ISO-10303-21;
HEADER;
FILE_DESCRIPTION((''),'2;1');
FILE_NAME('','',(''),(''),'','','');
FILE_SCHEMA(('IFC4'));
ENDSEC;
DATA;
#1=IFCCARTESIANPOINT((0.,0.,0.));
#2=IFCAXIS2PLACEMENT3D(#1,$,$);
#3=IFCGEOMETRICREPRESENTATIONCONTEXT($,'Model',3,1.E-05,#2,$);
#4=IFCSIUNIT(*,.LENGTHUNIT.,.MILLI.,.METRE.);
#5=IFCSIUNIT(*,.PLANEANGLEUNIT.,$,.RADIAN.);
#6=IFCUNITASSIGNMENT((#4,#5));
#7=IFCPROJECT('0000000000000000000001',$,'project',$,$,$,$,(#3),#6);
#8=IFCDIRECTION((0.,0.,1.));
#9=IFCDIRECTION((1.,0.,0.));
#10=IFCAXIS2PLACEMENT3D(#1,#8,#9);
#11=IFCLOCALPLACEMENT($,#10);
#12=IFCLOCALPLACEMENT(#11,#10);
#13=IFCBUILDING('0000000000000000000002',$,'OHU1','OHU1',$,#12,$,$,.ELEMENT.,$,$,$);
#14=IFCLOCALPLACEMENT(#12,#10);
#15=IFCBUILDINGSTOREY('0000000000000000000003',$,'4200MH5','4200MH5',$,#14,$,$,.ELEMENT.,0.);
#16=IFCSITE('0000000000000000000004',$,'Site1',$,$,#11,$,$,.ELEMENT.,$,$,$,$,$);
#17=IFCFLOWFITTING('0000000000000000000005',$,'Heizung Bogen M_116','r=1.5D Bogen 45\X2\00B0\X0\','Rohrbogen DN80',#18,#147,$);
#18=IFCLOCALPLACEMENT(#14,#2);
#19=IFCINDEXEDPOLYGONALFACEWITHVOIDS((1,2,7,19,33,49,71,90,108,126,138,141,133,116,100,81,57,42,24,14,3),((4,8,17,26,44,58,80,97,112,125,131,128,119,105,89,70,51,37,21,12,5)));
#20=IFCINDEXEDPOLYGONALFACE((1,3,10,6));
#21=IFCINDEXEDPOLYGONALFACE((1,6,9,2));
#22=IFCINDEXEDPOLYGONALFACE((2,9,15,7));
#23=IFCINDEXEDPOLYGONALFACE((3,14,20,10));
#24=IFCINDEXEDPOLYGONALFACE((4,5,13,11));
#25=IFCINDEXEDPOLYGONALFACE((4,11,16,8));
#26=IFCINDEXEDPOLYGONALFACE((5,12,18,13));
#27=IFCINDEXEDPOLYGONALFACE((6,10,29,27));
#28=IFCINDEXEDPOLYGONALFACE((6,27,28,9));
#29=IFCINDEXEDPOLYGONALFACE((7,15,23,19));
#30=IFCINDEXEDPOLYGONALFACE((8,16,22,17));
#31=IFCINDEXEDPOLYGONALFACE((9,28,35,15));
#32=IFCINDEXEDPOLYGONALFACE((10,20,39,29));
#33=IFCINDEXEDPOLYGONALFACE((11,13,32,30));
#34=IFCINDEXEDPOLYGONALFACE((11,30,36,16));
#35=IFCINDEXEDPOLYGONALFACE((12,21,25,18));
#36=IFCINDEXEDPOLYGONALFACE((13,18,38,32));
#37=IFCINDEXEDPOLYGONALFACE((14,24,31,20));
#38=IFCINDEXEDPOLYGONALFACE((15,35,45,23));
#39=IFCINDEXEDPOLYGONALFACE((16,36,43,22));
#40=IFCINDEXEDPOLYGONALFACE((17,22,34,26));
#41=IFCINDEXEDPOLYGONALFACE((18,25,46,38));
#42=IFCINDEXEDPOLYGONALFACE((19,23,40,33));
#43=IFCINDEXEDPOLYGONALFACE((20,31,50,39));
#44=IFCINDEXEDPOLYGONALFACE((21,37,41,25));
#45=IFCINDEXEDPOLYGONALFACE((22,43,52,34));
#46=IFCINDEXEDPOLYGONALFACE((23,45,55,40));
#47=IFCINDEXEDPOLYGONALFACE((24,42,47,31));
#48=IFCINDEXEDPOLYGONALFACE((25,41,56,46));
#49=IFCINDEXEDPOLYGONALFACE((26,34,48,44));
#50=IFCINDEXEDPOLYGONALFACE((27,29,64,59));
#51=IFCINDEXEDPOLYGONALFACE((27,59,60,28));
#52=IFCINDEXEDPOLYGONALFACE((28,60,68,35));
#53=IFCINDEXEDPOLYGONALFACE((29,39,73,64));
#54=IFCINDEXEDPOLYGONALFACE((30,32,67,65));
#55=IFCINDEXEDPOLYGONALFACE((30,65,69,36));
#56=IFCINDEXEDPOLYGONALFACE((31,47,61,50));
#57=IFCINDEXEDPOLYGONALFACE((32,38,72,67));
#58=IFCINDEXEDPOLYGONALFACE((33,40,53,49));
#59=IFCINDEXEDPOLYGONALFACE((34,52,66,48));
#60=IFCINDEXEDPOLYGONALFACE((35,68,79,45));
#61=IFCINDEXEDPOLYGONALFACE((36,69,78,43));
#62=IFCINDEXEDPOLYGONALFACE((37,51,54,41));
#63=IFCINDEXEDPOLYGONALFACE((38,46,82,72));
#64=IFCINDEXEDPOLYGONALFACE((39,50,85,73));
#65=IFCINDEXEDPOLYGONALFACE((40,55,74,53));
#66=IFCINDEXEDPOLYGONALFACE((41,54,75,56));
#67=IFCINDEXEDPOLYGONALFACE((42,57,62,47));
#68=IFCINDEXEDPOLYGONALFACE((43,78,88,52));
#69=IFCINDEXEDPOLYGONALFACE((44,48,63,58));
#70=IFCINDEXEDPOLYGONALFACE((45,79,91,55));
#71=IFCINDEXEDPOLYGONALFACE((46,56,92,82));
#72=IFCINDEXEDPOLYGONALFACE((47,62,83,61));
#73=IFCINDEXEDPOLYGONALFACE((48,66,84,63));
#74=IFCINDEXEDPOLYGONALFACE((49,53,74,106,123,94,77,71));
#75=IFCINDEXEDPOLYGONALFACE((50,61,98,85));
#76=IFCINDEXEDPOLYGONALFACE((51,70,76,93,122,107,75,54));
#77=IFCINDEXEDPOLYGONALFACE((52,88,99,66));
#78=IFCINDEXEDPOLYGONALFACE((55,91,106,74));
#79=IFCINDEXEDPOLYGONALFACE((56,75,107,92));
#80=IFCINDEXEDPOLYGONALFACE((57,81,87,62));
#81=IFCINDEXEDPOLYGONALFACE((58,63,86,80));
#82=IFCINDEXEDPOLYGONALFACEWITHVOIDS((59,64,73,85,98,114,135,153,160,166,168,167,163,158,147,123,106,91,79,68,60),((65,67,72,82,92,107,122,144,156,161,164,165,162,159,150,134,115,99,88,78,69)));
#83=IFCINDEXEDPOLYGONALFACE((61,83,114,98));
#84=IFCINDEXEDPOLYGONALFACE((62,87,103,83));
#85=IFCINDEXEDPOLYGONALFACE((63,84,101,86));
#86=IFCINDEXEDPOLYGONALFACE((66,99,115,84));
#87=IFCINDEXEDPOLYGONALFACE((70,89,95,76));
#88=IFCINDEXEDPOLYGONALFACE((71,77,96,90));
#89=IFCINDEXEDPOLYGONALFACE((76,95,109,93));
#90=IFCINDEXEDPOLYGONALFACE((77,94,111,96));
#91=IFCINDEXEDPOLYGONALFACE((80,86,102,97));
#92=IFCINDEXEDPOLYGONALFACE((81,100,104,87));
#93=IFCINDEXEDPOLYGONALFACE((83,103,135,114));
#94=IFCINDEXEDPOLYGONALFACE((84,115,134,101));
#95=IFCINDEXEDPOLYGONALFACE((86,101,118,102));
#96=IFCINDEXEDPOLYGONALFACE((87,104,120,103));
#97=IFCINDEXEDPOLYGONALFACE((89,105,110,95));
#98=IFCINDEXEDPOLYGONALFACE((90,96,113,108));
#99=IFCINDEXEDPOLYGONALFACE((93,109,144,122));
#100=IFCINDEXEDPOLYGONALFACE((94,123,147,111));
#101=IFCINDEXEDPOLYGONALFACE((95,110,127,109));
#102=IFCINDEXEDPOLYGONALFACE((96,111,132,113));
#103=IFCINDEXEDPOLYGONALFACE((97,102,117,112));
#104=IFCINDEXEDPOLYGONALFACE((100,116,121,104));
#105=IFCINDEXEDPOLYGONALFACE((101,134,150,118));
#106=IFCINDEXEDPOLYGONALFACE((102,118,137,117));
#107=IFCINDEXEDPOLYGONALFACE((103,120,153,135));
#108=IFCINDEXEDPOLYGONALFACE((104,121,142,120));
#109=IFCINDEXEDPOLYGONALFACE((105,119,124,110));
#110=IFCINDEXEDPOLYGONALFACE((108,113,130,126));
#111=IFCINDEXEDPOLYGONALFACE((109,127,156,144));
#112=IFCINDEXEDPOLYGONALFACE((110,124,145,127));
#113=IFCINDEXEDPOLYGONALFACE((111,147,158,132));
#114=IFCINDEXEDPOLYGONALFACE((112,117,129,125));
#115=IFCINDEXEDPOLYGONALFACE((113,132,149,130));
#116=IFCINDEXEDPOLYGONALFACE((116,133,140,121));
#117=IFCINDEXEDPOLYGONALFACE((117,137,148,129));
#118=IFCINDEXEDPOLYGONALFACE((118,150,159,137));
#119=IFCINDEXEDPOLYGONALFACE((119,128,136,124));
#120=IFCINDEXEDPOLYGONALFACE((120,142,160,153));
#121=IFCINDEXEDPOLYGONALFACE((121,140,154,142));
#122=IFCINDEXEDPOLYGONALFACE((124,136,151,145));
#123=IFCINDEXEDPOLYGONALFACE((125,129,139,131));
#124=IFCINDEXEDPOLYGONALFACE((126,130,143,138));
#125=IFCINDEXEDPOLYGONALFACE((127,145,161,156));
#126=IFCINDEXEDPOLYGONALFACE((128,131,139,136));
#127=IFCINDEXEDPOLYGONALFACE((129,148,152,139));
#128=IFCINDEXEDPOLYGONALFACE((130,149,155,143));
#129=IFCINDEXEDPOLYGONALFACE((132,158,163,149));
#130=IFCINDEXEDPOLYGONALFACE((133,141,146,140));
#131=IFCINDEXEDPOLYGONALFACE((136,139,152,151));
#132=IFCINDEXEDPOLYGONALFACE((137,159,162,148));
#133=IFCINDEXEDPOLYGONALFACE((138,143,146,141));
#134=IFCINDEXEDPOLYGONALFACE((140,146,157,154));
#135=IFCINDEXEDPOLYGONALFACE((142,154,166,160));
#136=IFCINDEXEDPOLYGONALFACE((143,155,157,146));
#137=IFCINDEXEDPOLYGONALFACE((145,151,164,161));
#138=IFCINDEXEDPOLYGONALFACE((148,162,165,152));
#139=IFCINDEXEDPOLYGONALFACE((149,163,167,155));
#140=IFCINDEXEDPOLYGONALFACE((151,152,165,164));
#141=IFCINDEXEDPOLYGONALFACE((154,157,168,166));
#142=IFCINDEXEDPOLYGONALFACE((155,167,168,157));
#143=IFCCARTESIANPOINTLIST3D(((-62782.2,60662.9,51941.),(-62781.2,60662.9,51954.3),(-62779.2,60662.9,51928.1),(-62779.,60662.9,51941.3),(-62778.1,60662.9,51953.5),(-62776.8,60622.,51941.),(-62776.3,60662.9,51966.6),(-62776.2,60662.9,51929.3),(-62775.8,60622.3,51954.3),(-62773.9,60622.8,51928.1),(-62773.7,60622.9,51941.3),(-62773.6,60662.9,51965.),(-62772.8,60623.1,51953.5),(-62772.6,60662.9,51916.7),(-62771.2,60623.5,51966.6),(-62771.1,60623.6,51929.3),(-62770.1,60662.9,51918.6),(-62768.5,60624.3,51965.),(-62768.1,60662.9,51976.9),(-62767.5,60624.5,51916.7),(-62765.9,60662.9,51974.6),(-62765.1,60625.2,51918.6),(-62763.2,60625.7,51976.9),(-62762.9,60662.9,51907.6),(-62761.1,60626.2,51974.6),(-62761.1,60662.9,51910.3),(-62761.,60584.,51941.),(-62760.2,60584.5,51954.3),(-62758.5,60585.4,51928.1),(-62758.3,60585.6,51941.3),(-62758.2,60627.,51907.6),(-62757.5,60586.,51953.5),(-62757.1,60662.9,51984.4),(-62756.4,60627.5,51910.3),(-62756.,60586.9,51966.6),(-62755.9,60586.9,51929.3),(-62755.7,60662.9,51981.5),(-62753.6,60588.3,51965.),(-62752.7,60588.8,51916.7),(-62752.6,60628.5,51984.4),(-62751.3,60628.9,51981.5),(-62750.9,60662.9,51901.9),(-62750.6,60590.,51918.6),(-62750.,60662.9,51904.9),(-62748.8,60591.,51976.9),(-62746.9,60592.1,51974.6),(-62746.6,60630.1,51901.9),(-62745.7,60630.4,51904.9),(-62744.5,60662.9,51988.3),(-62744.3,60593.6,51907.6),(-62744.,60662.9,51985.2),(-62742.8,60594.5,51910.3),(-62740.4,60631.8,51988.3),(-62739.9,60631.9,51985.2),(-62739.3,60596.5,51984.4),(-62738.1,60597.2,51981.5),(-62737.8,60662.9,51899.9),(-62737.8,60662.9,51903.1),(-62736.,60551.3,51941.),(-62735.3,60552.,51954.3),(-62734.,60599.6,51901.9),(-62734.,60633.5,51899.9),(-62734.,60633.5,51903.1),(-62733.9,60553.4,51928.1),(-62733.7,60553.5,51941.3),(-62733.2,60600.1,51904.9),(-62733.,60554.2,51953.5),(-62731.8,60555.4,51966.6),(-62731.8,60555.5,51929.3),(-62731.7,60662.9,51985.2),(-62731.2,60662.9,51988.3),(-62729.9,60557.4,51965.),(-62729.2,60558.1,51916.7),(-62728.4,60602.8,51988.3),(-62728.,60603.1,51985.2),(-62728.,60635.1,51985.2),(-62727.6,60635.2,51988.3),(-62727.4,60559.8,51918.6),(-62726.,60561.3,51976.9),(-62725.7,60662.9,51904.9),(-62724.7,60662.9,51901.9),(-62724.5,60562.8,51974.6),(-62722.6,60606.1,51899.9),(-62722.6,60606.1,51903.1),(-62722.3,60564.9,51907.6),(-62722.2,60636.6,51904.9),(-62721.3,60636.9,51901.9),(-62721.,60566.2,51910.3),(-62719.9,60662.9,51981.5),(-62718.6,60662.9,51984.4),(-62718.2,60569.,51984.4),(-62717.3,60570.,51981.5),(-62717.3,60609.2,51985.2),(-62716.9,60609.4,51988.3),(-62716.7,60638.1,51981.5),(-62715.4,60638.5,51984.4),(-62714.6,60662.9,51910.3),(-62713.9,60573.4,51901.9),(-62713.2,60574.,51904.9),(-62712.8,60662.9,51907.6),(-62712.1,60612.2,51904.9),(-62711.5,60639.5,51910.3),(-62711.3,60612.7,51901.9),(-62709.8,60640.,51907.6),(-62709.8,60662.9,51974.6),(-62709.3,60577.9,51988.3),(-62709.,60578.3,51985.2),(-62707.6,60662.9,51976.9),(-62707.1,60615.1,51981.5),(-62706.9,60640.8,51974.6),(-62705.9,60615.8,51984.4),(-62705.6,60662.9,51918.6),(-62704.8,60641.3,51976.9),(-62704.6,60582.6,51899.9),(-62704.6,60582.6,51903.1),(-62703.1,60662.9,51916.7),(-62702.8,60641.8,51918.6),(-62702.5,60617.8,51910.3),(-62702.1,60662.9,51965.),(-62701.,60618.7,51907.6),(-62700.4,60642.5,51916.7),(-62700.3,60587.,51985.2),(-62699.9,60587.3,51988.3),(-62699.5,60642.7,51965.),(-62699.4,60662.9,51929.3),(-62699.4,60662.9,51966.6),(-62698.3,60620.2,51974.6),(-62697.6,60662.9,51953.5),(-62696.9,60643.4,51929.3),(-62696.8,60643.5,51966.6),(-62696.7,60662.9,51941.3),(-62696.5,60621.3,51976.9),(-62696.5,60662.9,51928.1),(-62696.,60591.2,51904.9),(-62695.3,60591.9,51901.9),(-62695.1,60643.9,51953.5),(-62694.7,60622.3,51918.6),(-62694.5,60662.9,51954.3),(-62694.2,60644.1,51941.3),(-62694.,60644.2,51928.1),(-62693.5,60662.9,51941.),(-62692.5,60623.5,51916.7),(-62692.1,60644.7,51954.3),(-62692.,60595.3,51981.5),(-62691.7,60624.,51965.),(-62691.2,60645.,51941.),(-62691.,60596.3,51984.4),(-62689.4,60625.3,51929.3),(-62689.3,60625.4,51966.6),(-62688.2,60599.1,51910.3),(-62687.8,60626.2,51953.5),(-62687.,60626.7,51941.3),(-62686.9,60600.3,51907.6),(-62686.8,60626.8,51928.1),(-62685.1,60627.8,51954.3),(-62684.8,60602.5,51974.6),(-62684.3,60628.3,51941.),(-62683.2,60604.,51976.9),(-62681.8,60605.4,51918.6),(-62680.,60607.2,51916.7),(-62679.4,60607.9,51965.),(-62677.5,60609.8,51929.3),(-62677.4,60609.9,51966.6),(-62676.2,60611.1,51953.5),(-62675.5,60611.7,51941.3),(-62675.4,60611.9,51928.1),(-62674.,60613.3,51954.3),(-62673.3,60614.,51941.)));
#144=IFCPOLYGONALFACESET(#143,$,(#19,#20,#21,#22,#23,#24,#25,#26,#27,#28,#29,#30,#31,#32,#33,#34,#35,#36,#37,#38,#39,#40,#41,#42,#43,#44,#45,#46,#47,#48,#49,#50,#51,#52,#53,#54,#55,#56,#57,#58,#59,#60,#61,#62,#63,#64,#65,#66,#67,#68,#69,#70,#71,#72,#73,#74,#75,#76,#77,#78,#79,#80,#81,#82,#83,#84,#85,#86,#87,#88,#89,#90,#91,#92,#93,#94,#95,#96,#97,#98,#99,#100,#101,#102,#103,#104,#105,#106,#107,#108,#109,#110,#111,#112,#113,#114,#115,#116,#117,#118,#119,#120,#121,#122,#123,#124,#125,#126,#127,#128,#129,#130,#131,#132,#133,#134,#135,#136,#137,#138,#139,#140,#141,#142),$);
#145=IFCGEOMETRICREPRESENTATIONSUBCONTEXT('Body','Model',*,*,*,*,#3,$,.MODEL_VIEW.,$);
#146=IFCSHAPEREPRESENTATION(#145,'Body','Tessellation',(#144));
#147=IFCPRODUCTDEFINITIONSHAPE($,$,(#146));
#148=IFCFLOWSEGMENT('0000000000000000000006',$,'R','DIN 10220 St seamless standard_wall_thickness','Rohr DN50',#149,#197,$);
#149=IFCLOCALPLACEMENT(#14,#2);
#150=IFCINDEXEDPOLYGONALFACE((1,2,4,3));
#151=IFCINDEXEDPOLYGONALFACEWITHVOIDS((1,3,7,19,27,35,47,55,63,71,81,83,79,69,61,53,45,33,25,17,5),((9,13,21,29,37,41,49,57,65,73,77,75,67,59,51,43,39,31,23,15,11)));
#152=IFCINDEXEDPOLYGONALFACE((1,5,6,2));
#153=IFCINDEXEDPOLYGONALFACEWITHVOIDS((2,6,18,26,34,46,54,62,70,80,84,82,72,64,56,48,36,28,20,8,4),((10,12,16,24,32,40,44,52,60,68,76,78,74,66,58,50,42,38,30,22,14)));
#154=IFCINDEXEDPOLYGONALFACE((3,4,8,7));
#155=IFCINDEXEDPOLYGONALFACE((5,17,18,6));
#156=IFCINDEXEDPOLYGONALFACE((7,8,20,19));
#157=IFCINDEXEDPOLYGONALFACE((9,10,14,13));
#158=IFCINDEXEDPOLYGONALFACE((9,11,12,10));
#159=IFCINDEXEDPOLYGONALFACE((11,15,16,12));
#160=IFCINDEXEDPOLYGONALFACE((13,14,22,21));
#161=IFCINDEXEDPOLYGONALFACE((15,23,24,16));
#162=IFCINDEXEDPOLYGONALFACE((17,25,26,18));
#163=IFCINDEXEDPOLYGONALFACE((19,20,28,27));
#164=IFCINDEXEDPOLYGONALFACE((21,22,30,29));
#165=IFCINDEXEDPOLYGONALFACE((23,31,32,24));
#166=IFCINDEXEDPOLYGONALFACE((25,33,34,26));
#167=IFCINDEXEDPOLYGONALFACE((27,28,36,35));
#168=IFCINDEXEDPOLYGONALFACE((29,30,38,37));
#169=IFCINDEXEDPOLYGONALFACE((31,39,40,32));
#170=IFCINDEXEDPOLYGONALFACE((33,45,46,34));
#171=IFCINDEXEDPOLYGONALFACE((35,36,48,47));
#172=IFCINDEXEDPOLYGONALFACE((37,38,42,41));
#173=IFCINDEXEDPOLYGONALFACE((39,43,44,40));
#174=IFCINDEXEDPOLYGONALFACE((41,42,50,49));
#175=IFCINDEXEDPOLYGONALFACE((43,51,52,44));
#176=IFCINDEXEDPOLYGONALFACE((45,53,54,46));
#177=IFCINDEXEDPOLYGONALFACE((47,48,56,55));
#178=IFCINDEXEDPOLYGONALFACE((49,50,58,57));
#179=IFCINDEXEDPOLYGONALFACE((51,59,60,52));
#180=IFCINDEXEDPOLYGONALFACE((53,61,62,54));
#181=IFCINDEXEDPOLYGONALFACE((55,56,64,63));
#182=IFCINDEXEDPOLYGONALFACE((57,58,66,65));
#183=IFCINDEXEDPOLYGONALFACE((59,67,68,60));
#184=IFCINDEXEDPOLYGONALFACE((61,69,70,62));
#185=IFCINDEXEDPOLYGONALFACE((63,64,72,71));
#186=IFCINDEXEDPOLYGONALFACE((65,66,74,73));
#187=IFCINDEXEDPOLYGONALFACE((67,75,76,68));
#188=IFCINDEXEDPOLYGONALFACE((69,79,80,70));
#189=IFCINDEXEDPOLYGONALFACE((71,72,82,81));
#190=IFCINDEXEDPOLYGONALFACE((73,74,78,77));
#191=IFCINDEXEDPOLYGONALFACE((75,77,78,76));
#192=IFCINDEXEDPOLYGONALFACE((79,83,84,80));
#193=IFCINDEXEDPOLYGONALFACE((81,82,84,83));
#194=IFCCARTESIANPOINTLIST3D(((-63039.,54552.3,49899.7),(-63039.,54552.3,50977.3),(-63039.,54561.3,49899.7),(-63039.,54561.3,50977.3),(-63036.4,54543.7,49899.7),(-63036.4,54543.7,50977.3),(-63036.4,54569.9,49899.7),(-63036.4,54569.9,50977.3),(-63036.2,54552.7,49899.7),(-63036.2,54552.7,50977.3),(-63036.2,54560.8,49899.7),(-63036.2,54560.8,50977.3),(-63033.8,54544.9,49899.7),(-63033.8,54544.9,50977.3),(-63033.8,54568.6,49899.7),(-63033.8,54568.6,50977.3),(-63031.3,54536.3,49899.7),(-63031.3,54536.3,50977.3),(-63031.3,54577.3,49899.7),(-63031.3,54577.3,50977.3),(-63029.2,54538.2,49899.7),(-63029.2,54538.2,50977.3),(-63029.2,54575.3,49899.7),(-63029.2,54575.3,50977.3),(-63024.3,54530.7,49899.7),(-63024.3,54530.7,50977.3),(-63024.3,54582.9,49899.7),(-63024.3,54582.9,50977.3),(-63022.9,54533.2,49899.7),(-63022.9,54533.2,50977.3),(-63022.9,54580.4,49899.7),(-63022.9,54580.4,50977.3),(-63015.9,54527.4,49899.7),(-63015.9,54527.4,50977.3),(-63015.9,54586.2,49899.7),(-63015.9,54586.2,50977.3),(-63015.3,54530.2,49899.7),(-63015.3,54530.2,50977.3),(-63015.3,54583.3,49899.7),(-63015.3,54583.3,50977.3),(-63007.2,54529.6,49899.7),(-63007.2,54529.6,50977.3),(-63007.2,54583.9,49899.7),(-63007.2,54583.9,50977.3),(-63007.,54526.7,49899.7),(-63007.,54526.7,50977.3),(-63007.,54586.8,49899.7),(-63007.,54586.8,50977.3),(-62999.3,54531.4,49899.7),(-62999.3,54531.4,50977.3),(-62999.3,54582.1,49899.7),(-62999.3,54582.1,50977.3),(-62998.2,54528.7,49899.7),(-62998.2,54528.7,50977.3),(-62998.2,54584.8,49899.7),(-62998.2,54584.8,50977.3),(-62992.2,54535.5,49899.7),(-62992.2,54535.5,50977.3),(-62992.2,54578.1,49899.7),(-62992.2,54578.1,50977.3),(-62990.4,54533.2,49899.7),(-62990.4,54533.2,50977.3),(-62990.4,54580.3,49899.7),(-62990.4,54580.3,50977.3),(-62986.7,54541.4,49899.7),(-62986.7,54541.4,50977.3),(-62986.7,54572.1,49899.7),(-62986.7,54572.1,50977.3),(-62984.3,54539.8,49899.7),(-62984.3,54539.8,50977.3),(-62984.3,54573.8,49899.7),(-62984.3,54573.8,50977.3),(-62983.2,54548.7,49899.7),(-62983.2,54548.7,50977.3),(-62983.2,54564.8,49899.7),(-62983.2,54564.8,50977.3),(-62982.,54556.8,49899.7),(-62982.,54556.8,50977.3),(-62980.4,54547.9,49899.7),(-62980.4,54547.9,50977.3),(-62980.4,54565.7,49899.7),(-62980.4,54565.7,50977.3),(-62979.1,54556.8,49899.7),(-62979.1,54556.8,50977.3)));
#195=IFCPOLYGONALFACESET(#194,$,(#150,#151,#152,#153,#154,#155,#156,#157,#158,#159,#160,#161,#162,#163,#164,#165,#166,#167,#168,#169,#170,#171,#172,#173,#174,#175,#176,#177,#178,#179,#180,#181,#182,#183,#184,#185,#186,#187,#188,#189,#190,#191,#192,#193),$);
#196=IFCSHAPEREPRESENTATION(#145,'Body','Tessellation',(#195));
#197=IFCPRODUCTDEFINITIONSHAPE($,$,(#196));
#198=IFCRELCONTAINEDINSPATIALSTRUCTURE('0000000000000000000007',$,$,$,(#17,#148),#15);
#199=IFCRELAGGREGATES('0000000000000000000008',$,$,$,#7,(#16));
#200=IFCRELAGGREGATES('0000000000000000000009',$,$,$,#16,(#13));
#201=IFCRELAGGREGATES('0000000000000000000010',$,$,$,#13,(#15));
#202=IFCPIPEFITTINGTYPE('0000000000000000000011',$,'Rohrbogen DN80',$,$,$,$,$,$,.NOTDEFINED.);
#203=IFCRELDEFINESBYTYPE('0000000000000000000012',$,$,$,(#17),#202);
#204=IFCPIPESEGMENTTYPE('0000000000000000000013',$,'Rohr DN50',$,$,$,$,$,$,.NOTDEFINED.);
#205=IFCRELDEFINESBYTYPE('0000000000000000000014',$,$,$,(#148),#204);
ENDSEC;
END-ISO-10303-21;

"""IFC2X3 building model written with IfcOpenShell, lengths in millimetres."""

from ifc_helpers import new_model, entity, si_unit, frame, origin, origin_with_axes, origin_2d_with_axis, place, context, subcontext, project, spatial, hollow_circle, extrude, type_object, element, save


model = new_model("IFC2X3")

# Units and contexts
model_context = context("Model", 3, precision=1e-05, world=origin())
body_context = subcontext(model_context, "Body", "Model", "MODEL_VIEW")
ifc_project = project(units=[si_unit("LENGTHUNIT", "METRE", prefix="MILLI"), si_unit("PLANEANGLEUNIT", "RADIAN")], contexts=[model_context])

# Site, building, storey
site_placement = place(None, origin_with_axes())
site = spatial("IfcSite", under=ifc_project, at=site_placement, Name="Site1", CompositionType="ELEMENT")
building_placement = place(site_placement, origin_with_axes())
building = spatial("IfcBuilding", under=site, at=building_placement, Name="OHU1", Description="OHU1", CompositionType="ELEMENT")
storey_placement = place(building_placement, origin_with_axes())
storey = spatial("IfcBuildingStorey", under=building, at=storey_placement, Name="4200MH5", Description="4200MH5", CompositionType="ELEMENT", Elevation=0.0)

# Flow fitting
pipe_fitting_type_1 = type_object("IfcPipeFittingType", Name="Rohrbogen DN80", PredefinedType="NOTDEFINED")
flow_fitting_1_placement = place(storey_placement, frame((-62737.8, 60582.8, 51944.4), z_axis=(0.0, 0.0, 1.0), x_axis=(1.0, 0.0, 0.0)))
element("IfcFlowFitting", 1, at=flow_fitting_1_placement, inside=storey, type_object=pipe_fitting_type_1, Name="Heizung Bogen M_116", Description="r=1.5D Bogen 45°", ObjectType="Rohrbogen DN80", context=body_context, shape_type="SweptSolid", body=[
    entity("IfcRevolvedAreaSolid", entity("IfcCircleHollowProfileDef", "AREA", None, entity("IfcAxis2Placement2D", entity("IfcCartesianPoint", [0.0, 0.0]), entity("IfcDirection", [1.0, 0.0])), 44.5, 3.2), entity("IfcAxis2Placement3D", entity("IfcCartesianPoint", [0.0, 80.1, 0.0]), entity("IfcDirection", [-0.000003, -1.0, 0.0]), entity("IfcDirection", [0.0, 0.0, -1.0])), entity("IfcAxis1Placement", entity("IfcCartesianPoint", [0.0, 113.5, 0.0]), entity("IfcDirection", [-1.0, 0.0, 0.0])), 0.785398),
])

# Flow segment
pipe_segment_type_1 = type_object("IfcPipeSegmentType", Name="Rohr DN50", PredefinedType="NOTDEFINED")
flow_segment_1_placement = place(storey_placement, frame((-63009.2, 54556.8, 50438.5), z_axis=(0.0, 0.0, 1.0), x_axis=(1.0, 0.0, 0.0)))
element("IfcFlowSegment", 2, at=flow_segment_1_placement, inside=storey, type_object=pipe_segment_type_1, Name="R", Description="DIN 10220 St seamless standard_wall_thickness", ObjectType="Rohr DN50", context=body_context, shape_type="SweptSolid", body=[
    extrude(hollow_circle(Radius=30.1, WallThickness=2.9, at=origin_2d_with_axis()), frame((0.0, 0.0, 538.8), z_axis=(0.0, 0.0, -1.0), x_axis=(1.0, 0.0, 0.0)), (0.0, 0.0, 1.0), 1077.6),
])

save(model, "model.ifc")
